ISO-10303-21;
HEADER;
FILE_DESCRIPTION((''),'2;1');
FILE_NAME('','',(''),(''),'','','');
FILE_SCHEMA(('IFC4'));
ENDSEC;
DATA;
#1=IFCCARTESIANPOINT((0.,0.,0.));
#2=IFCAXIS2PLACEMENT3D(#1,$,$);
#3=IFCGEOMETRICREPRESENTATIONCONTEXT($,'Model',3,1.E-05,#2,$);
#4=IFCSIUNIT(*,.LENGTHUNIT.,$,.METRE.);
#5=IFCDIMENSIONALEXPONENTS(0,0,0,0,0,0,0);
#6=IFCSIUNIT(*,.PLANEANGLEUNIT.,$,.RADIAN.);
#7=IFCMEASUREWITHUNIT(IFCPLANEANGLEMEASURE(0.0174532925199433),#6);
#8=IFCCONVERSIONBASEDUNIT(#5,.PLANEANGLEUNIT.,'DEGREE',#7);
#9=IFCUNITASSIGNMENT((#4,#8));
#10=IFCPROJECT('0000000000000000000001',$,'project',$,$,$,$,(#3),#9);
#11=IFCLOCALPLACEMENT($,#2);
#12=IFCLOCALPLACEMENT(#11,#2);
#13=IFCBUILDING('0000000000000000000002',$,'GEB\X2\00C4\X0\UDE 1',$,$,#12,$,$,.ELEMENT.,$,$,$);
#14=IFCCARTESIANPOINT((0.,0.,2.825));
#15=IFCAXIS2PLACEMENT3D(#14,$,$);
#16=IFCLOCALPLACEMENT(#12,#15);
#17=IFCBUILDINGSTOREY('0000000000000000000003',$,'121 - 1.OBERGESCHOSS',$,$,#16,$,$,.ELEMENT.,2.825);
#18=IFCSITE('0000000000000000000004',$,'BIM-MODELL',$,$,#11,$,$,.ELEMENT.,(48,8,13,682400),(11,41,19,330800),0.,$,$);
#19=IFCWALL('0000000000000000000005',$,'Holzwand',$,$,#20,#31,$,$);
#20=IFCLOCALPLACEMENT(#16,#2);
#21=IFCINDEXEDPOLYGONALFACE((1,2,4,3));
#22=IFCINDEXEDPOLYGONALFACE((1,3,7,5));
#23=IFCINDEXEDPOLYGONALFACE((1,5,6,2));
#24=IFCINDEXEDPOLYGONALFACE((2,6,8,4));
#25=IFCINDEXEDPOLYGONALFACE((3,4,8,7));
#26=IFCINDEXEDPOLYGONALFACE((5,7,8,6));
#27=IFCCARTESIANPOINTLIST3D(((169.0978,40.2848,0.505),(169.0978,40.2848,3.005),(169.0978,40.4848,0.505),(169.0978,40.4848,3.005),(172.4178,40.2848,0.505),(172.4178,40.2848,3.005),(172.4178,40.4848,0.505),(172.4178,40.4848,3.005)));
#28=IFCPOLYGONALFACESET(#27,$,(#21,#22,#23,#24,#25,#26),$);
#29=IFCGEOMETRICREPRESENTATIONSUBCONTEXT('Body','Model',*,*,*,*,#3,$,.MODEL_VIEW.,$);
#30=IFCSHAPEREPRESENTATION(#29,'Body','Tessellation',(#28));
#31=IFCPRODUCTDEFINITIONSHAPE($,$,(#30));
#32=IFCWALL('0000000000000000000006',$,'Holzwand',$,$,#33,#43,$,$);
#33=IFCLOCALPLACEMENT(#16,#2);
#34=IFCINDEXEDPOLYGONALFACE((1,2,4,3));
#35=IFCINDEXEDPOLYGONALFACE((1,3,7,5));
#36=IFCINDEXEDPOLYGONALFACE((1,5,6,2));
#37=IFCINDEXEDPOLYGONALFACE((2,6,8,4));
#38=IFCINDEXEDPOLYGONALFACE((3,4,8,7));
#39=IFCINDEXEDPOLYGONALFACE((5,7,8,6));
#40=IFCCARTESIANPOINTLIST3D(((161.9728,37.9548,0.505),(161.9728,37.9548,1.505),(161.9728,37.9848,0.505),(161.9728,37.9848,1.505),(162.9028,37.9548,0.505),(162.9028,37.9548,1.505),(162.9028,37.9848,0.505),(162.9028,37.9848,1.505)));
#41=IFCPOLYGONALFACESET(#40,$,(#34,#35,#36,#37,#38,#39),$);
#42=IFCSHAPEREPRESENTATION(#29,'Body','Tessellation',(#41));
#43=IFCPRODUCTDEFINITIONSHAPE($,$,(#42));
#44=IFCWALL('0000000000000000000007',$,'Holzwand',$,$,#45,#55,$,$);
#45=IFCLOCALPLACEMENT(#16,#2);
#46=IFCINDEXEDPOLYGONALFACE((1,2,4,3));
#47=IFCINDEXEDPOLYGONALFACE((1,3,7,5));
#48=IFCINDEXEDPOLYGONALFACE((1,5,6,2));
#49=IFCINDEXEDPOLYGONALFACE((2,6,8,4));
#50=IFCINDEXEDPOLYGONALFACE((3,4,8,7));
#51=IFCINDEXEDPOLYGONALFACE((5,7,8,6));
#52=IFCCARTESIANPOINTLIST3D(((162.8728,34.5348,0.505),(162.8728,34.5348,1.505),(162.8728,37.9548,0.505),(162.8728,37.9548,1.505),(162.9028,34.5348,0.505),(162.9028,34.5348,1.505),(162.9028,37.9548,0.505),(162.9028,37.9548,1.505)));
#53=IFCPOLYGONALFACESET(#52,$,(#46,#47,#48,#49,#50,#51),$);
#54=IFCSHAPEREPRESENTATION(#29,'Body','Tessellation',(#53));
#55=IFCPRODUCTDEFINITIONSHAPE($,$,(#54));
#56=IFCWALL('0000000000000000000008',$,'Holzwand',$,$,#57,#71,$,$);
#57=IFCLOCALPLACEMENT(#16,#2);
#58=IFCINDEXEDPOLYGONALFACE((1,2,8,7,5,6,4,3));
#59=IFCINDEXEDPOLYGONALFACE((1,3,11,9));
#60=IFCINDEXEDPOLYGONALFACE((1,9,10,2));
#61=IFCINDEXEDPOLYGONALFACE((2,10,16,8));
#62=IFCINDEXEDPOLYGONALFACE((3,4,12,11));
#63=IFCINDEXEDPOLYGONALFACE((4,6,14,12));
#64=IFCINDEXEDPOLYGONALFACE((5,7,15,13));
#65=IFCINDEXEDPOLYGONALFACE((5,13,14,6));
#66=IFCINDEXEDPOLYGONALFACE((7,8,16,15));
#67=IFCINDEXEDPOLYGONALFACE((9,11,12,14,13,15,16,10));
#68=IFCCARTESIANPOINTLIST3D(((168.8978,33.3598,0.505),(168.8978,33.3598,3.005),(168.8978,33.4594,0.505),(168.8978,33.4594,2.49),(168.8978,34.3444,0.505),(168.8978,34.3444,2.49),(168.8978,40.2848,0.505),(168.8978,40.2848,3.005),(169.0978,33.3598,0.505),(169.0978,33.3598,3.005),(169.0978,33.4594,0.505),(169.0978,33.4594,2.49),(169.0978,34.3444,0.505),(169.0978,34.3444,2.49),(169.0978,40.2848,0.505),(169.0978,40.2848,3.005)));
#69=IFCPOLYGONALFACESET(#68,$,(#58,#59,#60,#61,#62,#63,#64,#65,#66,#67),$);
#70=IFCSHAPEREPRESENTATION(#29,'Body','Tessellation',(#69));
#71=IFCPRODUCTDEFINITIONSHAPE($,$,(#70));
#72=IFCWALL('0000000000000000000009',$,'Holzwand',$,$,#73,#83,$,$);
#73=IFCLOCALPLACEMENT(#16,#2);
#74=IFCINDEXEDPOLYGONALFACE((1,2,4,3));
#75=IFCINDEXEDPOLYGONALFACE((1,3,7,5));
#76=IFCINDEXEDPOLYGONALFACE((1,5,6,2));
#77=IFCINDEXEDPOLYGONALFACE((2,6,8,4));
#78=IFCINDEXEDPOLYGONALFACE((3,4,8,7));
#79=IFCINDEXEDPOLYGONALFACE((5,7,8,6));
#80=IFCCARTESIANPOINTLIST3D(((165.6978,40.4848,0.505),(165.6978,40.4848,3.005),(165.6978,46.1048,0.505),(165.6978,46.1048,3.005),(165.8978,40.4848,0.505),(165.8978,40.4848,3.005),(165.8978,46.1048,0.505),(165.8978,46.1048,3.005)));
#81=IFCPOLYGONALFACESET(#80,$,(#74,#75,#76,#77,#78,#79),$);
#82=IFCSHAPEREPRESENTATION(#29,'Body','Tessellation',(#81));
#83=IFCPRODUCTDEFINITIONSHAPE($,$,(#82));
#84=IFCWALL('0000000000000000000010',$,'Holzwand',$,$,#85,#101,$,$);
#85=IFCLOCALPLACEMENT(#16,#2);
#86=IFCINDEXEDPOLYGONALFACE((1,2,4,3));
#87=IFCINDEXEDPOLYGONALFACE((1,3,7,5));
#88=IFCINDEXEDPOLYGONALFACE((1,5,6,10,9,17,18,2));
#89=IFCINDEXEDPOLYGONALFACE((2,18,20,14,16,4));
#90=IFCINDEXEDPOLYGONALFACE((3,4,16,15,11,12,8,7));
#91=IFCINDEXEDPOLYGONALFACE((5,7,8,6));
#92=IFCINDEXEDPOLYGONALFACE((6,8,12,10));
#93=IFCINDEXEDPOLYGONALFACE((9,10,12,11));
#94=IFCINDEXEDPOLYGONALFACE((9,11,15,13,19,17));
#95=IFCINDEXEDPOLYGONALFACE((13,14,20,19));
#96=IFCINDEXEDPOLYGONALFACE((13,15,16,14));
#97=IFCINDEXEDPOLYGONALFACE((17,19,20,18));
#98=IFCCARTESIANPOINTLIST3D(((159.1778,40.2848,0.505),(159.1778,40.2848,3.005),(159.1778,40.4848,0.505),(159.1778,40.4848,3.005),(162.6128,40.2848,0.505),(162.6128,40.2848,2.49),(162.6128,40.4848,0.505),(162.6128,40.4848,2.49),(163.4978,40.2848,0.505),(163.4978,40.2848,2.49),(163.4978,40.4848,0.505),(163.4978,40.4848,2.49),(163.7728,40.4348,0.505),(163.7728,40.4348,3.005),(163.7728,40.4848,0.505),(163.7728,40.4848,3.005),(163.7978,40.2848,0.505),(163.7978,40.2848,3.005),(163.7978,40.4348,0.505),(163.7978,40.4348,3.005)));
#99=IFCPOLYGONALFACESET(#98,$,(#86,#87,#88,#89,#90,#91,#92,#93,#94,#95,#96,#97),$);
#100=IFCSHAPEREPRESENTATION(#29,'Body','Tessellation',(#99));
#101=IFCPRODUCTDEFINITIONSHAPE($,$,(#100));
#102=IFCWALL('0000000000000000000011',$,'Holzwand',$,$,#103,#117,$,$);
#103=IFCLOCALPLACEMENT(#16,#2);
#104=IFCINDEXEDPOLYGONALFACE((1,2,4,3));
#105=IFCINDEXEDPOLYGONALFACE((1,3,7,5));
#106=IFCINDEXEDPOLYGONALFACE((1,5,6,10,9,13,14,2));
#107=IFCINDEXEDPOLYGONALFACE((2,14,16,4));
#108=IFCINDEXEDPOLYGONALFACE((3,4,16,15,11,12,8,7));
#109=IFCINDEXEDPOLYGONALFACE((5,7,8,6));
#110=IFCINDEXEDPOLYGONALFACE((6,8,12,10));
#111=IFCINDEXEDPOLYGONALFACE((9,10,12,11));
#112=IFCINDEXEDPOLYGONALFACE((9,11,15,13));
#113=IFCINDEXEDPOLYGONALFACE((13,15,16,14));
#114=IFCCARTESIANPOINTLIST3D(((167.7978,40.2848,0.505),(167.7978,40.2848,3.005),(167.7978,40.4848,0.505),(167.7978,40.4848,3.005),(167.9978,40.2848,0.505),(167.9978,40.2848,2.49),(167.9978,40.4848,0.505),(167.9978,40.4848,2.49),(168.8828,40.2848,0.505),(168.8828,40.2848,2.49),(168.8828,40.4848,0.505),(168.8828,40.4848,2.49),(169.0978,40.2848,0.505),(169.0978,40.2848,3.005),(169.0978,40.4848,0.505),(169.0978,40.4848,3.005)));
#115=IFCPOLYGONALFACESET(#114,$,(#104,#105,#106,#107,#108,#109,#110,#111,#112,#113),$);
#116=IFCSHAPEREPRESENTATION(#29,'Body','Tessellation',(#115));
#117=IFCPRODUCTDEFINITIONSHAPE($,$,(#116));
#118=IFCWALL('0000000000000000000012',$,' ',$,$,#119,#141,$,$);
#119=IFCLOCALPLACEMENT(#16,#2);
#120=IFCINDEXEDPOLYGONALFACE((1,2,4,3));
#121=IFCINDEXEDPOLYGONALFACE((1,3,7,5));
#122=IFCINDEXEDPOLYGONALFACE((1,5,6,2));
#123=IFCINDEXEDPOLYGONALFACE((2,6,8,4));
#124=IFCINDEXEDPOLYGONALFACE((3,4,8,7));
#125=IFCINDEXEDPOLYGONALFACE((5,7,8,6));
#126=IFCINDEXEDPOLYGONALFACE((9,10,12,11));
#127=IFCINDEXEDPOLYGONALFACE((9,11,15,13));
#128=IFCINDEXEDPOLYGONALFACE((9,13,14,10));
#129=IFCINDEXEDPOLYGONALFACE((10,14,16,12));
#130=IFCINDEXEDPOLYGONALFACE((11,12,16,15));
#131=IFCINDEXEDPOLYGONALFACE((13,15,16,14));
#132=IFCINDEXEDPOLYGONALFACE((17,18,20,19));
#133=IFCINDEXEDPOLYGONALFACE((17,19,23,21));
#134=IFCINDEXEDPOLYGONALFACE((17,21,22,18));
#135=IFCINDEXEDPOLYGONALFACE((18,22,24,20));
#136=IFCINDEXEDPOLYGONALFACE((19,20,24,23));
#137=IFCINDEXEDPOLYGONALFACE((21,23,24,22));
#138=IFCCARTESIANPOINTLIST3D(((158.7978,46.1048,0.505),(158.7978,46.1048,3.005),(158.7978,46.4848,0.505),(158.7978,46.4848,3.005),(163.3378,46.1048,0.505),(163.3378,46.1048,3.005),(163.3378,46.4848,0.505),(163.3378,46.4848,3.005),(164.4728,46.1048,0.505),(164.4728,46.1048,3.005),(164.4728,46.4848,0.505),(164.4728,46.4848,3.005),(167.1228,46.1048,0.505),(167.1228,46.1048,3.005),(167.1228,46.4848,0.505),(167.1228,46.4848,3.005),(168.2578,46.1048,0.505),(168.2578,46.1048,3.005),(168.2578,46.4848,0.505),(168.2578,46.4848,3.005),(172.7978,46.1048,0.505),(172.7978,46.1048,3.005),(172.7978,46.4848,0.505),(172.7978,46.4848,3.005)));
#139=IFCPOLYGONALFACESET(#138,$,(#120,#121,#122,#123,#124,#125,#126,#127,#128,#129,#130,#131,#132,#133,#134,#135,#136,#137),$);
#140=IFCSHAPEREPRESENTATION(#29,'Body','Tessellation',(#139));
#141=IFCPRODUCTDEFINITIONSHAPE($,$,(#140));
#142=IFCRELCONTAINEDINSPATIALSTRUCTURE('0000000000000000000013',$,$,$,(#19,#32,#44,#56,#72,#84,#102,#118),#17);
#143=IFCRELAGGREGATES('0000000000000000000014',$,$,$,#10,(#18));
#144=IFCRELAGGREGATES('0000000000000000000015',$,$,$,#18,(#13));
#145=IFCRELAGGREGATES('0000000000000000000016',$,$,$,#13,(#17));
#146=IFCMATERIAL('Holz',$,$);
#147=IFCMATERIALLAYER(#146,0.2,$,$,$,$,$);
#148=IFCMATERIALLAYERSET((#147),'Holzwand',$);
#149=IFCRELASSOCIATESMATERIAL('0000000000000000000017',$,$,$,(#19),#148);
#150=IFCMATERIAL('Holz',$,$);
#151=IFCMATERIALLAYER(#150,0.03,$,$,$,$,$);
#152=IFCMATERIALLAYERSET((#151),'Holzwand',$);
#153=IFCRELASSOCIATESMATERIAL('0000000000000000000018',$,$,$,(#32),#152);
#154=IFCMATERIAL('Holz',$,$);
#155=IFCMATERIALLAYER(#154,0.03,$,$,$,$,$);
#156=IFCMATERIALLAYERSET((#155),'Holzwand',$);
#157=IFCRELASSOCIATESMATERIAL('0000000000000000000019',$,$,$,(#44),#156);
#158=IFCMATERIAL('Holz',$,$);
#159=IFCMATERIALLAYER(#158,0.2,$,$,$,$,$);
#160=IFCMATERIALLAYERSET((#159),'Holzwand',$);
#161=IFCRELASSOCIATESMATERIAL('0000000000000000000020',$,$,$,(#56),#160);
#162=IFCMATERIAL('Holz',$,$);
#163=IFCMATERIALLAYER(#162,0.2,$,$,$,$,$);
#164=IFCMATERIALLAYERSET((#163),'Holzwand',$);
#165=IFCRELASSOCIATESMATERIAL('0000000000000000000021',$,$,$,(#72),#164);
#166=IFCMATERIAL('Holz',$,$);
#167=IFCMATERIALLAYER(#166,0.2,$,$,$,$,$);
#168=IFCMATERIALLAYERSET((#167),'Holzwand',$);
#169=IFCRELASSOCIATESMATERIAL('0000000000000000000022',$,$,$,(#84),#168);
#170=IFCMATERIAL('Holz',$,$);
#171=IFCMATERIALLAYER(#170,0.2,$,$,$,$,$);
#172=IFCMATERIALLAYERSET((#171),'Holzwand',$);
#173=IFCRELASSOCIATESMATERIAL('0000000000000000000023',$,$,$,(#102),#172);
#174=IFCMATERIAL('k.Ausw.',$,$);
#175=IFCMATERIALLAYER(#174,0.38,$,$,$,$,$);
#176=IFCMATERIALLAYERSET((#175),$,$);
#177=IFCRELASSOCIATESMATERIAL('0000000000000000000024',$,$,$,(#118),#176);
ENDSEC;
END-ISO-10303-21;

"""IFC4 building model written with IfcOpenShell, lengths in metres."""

from ifc_helpers import new_model, entity, si_unit, converted_unit, frame, frame_2d, origin, origin_with_axes, place, context, subcontext, project, spatial, polyline, rectangle, outline, extrude, material, layer, layer_set, layer_usage, element, save


model = new_model("IFC4")

# Units and contexts
model_context = context("Model", 3, precision=1e-05, world=origin())
body_context = subcontext(model_context, "Body", "Model", "MODEL_VIEW")
ifc_project = project(units=[si_unit("LENGTHUNIT", "METRE"), converted_unit("PLANEANGLEUNIT", "DEGREE", entity("IfcPlaneAngleMeasure", 0.0174532925199433), si_unit("PLANEANGLEUNIT", "RADIAN"), dimensions=[0, 0, 0, 0, 0, 0, 0])], contexts=[model_context])

# Site, building, storey
site_placement = place(None, origin())
site = spatial("IfcSite", under=ifc_project, at=site_placement, Name="BIM-MODELL", CompositionType="ELEMENT", RefLatitude=(48, 8, 13, 682400), RefLongitude=(11, 41, 19, 330800), RefElevation=0.0)
building_placement = place(site_placement, origin())
building = spatial("IfcBuilding", under=site, at=building_placement, Name="GEBÄUDE 1", CompositionType="ELEMENT")
storey_placement = place(building_placement, frame((0.0, 0.0, 2.825)))
storey = spatial("IfcBuildingStorey", under=building, at=storey_placement, Name="121 - 1.OBERGESCHOSS", CompositionType="ELEMENT", Elevation=2.825)

# Walls
ifc_material_1 = material(Name="Holz")
ifc_layer_1 = layer(ifc_material_1, 0.2)
ifc_layer_set_1 = layer_set([ifc_layer_1], Name="Holzwand")
ifc_layer_usage_1 = layer_usage(ifc_layer_set_1, "AXIS2", "POSITIVE", -0.1)
wall_1_placement = place(storey_placement, frame((172.4178, 40.4848, 0.505), z_axis=(0.0, 0.0, 1.0), x_axis=(-1.0, 0.0, 0.0)))
element("IfcWall", 1, at=wall_1_placement, inside=storey, material=ifc_layer_usage_1, Name="Holzwand", context=body_context, shape_type="SweptSolid", body=[
    extrude(rectangle(XDim=3.32, YDim=0.2, at=frame_2d((1.66, 0.1), x_axis=(1.0, 0.0))), origin_with_axes(), (0.0, 0.0, 1.0), 2.5),
])
ifc_material_2 = material(Name="Holz")
ifc_layer_2 = layer(ifc_material_2, 0.03)
ifc_layer_set_2 = layer_set([ifc_layer_2], Name="Holzwand")
ifc_layer_usage_2 = layer_usage(ifc_layer_set_2, "AXIS2", "POSITIVE", 0.0)
wall_2_placement = place(storey_placement, frame((161.9728, 37.9548, 0.505), z_axis=(0.0, 0.0, 1.0), x_axis=(1.0, 0.0, 0.0)))
element("IfcWall", 2, at=wall_2_placement, inside=storey, material=ifc_layer_usage_2, Name="Holzwand", context=body_context, shape_type="SweptSolid", body=[
    extrude(rectangle(XDim=0.93, YDim=0.03, at=frame_2d((0.465, 0.015), x_axis=(1.0, 0.0))), origin_with_axes(), (0.0, 0.0, 1.0), 1.0),
])
ifc_material_3 = material(Name="Holz")
ifc_layer_3 = layer(ifc_material_3, 0.03)
ifc_layer_set_3 = layer_set([ifc_layer_3], Name="Holzwand")
ifc_layer_usage_3 = layer_usage(ifc_layer_set_3, "AXIS2", "POSITIVE", 0.0)
wall_3_placement = place(storey_placement, frame((162.8728, 37.9548, 0.505), z_axis=(0.0, 0.0, 1.0), x_axis=(0.0, -1.0, 0.0)))
element("IfcWall", 3, at=wall_3_placement, inside=storey, material=ifc_layer_usage_3, Name="Holzwand", context=body_context, shape_type="SweptSolid", body=[
    extrude(rectangle(XDim=3.42, YDim=0.03, at=frame_2d((1.71, 0.015), x_axis=(1.0, 0.0))), origin_with_axes(), (0.0, 0.0, 1.0), 1.0),
])

# Wall, opening
ifc_material_4 = material(Name="Holz")
ifc_layer_4 = layer(ifc_material_4, 0.2)
ifc_layer_set_4 = layer_set([ifc_layer_4], Name="Holzwand")
ifc_layer_usage_4 = layer_usage(ifc_layer_set_4, "AXIS2", "POSITIVE", 0.0)
wall_4_placement = place(storey_placement, frame((168.8978, 40.2848, 0.505), z_axis=(0.0, 0.0, 1.0), x_axis=(0.0, -1.0, 0.0)))
wall_4 = element("IfcWall", 4, at=wall_4_placement, inside=storey, material=ifc_layer_usage_4, Name="Holzwand", context=body_context, shape_type="SweptSolid", body=[
    extrude(rectangle(XDim=6.925, YDim=0.2, at=frame_2d((3.4625, 0.1), x_axis=(1.0, 0.0))), origin_with_axes(), (0.0, 0.0, 1.0), 2.5),
])
opening_1_placement = place(wall_4_placement, frame((5.9404, 0.0, -0.15), z_axis=(0.0, 1.0, 0.0), x_axis=(0.0, 0.0, 1.0)))
element("IfcOpeningElement", 5, at=opening_1_placement, cuts=wall_4, ObjectType="Opening", context=body_context, shape_type="SweptSolid", body=[
    extrude(outline(polyline([(0.0, 0.885), (2.135, 0.885), (2.135, 0.0), (0.0, 0.0), (0.0, 0.885)])), origin_with_axes(), (0.0, 0.0, 1.0), 0.2),
])

# Wall
ifc_material_5 = material(Name="Holz")
ifc_layer_5 = layer(ifc_material_5, 0.2)
ifc_layer_set_5 = layer_set([ifc_layer_5], Name="Holzwand")
ifc_layer_usage_5 = layer_usage(ifc_layer_set_5, "AXIS2", "POSITIVE", 0.0)
wall_5_placement = place(storey_placement, frame((165.6978, 46.1048, 0.505), z_axis=(0.0, 0.0, 1.0), x_axis=(0.0, -1.0, 0.0)))
element("IfcWall", 6, at=wall_5_placement, inside=storey, material=ifc_layer_usage_5, Name="Holzwand", context=body_context, shape_type="SweptSolid", body=[
    extrude(rectangle(XDim=5.62, YDim=0.2, at=frame_2d((2.81, 0.1), x_axis=(1.0, 0.0))), origin_with_axes(), (0.0, 0.0, 1.0), 2.5),
])

# Walls, openings
ifc_material_6 = material(Name="Holz")
ifc_layer_6 = layer(ifc_material_6, 0.2)
ifc_layer_set_6 = layer_set([ifc_layer_6], Name="Holzwand")
ifc_layer_usage_6 = layer_usage(ifc_layer_set_6, "AXIS2", "POSITIVE", 0.0)
wall_6_placement = place(storey_placement, frame((163.7728, 40.4848, 0.505), z_axis=(0.0, 0.0, 1.0), x_axis=(-1.0, 0.0, 0.0)))
wall_6 = element("IfcWall", 7, at=wall_6_placement, inside=storey, material=ifc_layer_usage_6, Name="Holzwand", context=body_context, shape_type="SweptSolid", body=[
    extrude(outline(polyline([(-4.595, -0.2), (0.0, -0.2), (0.0, 0.0), (-4.62, 0.0), (-4.62, -0.15), (-4.595, -0.15), (-4.595, -0.2)])), frame((4.595, 0.2, 0.0), z_axis=(0.0, 0.0, 1.0), x_axis=(1.0, 0.0, 0.0)), (0.0, 0.0, 1.0), 2.5),
])
opening_2_placement = place(wall_6_placement, frame((1.16, 0.2, -0.15), z_axis=(0.0, -1.0, 0.0), x_axis=(0.0, 0.0, 1.0)))
element("IfcOpeningElement", 8, at=opening_2_placement, cuts=wall_6, ObjectType="Opening", context=body_context, shape_type="SweptSolid", body=[
    extrude(outline(polyline([(0.0, 0.885), (2.135, 0.885), (2.135, 0.0), (0.0, 0.0), (0.0, 0.885)])), origin_with_axes(), (0.0, 0.0, 1.0), 0.2),
])
ifc_material_7 = material(Name="Holz")
ifc_layer_7 = layer(ifc_material_7, 0.2)
ifc_layer_set_7 = layer_set([ifc_layer_7], Name="Holzwand")
ifc_layer_usage_7 = layer_usage(ifc_layer_set_7, "AXIS2", "POSITIVE", 0.0)
wall_7_placement = place(storey_placement, frame((169.0978, 40.4848, 0.505), z_axis=(0.0, 0.0, 1.0), x_axis=(-1.0, 0.0, 0.0)))
wall_7 = element("IfcWall", 9, at=wall_7_placement, inside=storey, material=ifc_layer_usage_7, Name="Holzwand", context=body_context, shape_type="SweptSolid", body=[
    extrude(rectangle(XDim=1.3, YDim=0.2, at=frame_2d((0.65, 0.1), x_axis=(1.0, 0.0))), origin_with_axes(), (0.0, 0.0, 1.0), 2.5),
])
opening_3_placement = place(wall_7_placement, frame((1.1, 0.2, -0.15), z_axis=(0.0, -1.0, 0.0), x_axis=(0.0, 0.0, 1.0)))
element("IfcOpeningElement", 10, at=opening_3_placement, cuts=wall_7, ObjectType="Opening", context=body_context, shape_type="SweptSolid", body=[
    extrude(outline(polyline([(0.0, 0.885), (2.135, 0.885), (2.135, 0.0), (0.0, 0.0), (0.0, 0.885)])), origin_with_axes(), (0.0, 0.0, 1.0), 0.2),
])

# Wall, openings
ifc_material_8 = material(Name="k.Ausw.")
ifc_layer_8 = layer(ifc_material_8, 0.38)
ifc_layer_set_8 = layer_set([ifc_layer_8])
ifc_layer_usage_8 = layer_usage(ifc_layer_set_8, "AXIS2", "POSITIVE", 0.0)
wall_8_placement = place(storey_placement, frame((172.7978, 46.4848, 0.505), z_axis=(0.0, 0.0, 1.0), x_axis=(-1.0, 0.0, 0.0)))
wall_8 = element("IfcWall", 11, at=wall_8_placement, inside=storey, material=ifc_layer_usage_8, Name=" ", context=body_context, shape_type="SweptSolid", body=[
    extrude(rectangle(XDim=14.0, YDim=0.38, at=frame_2d((7.0, 0.19), x_axis=(1.0, 0.0))), origin_with_axes(), (0.0, 0.0, 1.0), 2.5),
])
opening_4_placement = place(wall_8_placement, frame((9.46, 0.38, 0.0), z_axis=(0.0, -1.0, 0.0), x_axis=(0.0, 0.0, 1.0)))
element("IfcOpeningElement", 12, at=opening_4_placement, cuts=wall_8, ObjectType="Opening", context=body_context, shape_type="SweptSolid", body=[
    extrude(outline(polyline([(0.0, 1.135), (2.5, 1.135), (2.5, 0.0), (0.0, 0.0), (0.0, 1.135)])), origin_with_axes(), (0.0, 0.0, 1.0), 0.38),
])
opening_5_placement = place(wall_8_placement, frame((5.675, 0.38, 0.0), z_axis=(0.0, -1.0, 0.0), x_axis=(0.0, 0.0, 1.0)))
element("IfcOpeningElement", 13, at=opening_5_placement, cuts=wall_8, ObjectType="Opening", context=body_context, shape_type="SweptSolid", body=[
    extrude(outline(polyline([(0.0, 1.135), (2.5, 1.135), (2.5, 0.0), (0.0, 0.0), (0.0, 1.135)])), origin_with_axes(), (0.0, 0.0, 1.0), 0.38),
])

save(model, "model.ifc")
